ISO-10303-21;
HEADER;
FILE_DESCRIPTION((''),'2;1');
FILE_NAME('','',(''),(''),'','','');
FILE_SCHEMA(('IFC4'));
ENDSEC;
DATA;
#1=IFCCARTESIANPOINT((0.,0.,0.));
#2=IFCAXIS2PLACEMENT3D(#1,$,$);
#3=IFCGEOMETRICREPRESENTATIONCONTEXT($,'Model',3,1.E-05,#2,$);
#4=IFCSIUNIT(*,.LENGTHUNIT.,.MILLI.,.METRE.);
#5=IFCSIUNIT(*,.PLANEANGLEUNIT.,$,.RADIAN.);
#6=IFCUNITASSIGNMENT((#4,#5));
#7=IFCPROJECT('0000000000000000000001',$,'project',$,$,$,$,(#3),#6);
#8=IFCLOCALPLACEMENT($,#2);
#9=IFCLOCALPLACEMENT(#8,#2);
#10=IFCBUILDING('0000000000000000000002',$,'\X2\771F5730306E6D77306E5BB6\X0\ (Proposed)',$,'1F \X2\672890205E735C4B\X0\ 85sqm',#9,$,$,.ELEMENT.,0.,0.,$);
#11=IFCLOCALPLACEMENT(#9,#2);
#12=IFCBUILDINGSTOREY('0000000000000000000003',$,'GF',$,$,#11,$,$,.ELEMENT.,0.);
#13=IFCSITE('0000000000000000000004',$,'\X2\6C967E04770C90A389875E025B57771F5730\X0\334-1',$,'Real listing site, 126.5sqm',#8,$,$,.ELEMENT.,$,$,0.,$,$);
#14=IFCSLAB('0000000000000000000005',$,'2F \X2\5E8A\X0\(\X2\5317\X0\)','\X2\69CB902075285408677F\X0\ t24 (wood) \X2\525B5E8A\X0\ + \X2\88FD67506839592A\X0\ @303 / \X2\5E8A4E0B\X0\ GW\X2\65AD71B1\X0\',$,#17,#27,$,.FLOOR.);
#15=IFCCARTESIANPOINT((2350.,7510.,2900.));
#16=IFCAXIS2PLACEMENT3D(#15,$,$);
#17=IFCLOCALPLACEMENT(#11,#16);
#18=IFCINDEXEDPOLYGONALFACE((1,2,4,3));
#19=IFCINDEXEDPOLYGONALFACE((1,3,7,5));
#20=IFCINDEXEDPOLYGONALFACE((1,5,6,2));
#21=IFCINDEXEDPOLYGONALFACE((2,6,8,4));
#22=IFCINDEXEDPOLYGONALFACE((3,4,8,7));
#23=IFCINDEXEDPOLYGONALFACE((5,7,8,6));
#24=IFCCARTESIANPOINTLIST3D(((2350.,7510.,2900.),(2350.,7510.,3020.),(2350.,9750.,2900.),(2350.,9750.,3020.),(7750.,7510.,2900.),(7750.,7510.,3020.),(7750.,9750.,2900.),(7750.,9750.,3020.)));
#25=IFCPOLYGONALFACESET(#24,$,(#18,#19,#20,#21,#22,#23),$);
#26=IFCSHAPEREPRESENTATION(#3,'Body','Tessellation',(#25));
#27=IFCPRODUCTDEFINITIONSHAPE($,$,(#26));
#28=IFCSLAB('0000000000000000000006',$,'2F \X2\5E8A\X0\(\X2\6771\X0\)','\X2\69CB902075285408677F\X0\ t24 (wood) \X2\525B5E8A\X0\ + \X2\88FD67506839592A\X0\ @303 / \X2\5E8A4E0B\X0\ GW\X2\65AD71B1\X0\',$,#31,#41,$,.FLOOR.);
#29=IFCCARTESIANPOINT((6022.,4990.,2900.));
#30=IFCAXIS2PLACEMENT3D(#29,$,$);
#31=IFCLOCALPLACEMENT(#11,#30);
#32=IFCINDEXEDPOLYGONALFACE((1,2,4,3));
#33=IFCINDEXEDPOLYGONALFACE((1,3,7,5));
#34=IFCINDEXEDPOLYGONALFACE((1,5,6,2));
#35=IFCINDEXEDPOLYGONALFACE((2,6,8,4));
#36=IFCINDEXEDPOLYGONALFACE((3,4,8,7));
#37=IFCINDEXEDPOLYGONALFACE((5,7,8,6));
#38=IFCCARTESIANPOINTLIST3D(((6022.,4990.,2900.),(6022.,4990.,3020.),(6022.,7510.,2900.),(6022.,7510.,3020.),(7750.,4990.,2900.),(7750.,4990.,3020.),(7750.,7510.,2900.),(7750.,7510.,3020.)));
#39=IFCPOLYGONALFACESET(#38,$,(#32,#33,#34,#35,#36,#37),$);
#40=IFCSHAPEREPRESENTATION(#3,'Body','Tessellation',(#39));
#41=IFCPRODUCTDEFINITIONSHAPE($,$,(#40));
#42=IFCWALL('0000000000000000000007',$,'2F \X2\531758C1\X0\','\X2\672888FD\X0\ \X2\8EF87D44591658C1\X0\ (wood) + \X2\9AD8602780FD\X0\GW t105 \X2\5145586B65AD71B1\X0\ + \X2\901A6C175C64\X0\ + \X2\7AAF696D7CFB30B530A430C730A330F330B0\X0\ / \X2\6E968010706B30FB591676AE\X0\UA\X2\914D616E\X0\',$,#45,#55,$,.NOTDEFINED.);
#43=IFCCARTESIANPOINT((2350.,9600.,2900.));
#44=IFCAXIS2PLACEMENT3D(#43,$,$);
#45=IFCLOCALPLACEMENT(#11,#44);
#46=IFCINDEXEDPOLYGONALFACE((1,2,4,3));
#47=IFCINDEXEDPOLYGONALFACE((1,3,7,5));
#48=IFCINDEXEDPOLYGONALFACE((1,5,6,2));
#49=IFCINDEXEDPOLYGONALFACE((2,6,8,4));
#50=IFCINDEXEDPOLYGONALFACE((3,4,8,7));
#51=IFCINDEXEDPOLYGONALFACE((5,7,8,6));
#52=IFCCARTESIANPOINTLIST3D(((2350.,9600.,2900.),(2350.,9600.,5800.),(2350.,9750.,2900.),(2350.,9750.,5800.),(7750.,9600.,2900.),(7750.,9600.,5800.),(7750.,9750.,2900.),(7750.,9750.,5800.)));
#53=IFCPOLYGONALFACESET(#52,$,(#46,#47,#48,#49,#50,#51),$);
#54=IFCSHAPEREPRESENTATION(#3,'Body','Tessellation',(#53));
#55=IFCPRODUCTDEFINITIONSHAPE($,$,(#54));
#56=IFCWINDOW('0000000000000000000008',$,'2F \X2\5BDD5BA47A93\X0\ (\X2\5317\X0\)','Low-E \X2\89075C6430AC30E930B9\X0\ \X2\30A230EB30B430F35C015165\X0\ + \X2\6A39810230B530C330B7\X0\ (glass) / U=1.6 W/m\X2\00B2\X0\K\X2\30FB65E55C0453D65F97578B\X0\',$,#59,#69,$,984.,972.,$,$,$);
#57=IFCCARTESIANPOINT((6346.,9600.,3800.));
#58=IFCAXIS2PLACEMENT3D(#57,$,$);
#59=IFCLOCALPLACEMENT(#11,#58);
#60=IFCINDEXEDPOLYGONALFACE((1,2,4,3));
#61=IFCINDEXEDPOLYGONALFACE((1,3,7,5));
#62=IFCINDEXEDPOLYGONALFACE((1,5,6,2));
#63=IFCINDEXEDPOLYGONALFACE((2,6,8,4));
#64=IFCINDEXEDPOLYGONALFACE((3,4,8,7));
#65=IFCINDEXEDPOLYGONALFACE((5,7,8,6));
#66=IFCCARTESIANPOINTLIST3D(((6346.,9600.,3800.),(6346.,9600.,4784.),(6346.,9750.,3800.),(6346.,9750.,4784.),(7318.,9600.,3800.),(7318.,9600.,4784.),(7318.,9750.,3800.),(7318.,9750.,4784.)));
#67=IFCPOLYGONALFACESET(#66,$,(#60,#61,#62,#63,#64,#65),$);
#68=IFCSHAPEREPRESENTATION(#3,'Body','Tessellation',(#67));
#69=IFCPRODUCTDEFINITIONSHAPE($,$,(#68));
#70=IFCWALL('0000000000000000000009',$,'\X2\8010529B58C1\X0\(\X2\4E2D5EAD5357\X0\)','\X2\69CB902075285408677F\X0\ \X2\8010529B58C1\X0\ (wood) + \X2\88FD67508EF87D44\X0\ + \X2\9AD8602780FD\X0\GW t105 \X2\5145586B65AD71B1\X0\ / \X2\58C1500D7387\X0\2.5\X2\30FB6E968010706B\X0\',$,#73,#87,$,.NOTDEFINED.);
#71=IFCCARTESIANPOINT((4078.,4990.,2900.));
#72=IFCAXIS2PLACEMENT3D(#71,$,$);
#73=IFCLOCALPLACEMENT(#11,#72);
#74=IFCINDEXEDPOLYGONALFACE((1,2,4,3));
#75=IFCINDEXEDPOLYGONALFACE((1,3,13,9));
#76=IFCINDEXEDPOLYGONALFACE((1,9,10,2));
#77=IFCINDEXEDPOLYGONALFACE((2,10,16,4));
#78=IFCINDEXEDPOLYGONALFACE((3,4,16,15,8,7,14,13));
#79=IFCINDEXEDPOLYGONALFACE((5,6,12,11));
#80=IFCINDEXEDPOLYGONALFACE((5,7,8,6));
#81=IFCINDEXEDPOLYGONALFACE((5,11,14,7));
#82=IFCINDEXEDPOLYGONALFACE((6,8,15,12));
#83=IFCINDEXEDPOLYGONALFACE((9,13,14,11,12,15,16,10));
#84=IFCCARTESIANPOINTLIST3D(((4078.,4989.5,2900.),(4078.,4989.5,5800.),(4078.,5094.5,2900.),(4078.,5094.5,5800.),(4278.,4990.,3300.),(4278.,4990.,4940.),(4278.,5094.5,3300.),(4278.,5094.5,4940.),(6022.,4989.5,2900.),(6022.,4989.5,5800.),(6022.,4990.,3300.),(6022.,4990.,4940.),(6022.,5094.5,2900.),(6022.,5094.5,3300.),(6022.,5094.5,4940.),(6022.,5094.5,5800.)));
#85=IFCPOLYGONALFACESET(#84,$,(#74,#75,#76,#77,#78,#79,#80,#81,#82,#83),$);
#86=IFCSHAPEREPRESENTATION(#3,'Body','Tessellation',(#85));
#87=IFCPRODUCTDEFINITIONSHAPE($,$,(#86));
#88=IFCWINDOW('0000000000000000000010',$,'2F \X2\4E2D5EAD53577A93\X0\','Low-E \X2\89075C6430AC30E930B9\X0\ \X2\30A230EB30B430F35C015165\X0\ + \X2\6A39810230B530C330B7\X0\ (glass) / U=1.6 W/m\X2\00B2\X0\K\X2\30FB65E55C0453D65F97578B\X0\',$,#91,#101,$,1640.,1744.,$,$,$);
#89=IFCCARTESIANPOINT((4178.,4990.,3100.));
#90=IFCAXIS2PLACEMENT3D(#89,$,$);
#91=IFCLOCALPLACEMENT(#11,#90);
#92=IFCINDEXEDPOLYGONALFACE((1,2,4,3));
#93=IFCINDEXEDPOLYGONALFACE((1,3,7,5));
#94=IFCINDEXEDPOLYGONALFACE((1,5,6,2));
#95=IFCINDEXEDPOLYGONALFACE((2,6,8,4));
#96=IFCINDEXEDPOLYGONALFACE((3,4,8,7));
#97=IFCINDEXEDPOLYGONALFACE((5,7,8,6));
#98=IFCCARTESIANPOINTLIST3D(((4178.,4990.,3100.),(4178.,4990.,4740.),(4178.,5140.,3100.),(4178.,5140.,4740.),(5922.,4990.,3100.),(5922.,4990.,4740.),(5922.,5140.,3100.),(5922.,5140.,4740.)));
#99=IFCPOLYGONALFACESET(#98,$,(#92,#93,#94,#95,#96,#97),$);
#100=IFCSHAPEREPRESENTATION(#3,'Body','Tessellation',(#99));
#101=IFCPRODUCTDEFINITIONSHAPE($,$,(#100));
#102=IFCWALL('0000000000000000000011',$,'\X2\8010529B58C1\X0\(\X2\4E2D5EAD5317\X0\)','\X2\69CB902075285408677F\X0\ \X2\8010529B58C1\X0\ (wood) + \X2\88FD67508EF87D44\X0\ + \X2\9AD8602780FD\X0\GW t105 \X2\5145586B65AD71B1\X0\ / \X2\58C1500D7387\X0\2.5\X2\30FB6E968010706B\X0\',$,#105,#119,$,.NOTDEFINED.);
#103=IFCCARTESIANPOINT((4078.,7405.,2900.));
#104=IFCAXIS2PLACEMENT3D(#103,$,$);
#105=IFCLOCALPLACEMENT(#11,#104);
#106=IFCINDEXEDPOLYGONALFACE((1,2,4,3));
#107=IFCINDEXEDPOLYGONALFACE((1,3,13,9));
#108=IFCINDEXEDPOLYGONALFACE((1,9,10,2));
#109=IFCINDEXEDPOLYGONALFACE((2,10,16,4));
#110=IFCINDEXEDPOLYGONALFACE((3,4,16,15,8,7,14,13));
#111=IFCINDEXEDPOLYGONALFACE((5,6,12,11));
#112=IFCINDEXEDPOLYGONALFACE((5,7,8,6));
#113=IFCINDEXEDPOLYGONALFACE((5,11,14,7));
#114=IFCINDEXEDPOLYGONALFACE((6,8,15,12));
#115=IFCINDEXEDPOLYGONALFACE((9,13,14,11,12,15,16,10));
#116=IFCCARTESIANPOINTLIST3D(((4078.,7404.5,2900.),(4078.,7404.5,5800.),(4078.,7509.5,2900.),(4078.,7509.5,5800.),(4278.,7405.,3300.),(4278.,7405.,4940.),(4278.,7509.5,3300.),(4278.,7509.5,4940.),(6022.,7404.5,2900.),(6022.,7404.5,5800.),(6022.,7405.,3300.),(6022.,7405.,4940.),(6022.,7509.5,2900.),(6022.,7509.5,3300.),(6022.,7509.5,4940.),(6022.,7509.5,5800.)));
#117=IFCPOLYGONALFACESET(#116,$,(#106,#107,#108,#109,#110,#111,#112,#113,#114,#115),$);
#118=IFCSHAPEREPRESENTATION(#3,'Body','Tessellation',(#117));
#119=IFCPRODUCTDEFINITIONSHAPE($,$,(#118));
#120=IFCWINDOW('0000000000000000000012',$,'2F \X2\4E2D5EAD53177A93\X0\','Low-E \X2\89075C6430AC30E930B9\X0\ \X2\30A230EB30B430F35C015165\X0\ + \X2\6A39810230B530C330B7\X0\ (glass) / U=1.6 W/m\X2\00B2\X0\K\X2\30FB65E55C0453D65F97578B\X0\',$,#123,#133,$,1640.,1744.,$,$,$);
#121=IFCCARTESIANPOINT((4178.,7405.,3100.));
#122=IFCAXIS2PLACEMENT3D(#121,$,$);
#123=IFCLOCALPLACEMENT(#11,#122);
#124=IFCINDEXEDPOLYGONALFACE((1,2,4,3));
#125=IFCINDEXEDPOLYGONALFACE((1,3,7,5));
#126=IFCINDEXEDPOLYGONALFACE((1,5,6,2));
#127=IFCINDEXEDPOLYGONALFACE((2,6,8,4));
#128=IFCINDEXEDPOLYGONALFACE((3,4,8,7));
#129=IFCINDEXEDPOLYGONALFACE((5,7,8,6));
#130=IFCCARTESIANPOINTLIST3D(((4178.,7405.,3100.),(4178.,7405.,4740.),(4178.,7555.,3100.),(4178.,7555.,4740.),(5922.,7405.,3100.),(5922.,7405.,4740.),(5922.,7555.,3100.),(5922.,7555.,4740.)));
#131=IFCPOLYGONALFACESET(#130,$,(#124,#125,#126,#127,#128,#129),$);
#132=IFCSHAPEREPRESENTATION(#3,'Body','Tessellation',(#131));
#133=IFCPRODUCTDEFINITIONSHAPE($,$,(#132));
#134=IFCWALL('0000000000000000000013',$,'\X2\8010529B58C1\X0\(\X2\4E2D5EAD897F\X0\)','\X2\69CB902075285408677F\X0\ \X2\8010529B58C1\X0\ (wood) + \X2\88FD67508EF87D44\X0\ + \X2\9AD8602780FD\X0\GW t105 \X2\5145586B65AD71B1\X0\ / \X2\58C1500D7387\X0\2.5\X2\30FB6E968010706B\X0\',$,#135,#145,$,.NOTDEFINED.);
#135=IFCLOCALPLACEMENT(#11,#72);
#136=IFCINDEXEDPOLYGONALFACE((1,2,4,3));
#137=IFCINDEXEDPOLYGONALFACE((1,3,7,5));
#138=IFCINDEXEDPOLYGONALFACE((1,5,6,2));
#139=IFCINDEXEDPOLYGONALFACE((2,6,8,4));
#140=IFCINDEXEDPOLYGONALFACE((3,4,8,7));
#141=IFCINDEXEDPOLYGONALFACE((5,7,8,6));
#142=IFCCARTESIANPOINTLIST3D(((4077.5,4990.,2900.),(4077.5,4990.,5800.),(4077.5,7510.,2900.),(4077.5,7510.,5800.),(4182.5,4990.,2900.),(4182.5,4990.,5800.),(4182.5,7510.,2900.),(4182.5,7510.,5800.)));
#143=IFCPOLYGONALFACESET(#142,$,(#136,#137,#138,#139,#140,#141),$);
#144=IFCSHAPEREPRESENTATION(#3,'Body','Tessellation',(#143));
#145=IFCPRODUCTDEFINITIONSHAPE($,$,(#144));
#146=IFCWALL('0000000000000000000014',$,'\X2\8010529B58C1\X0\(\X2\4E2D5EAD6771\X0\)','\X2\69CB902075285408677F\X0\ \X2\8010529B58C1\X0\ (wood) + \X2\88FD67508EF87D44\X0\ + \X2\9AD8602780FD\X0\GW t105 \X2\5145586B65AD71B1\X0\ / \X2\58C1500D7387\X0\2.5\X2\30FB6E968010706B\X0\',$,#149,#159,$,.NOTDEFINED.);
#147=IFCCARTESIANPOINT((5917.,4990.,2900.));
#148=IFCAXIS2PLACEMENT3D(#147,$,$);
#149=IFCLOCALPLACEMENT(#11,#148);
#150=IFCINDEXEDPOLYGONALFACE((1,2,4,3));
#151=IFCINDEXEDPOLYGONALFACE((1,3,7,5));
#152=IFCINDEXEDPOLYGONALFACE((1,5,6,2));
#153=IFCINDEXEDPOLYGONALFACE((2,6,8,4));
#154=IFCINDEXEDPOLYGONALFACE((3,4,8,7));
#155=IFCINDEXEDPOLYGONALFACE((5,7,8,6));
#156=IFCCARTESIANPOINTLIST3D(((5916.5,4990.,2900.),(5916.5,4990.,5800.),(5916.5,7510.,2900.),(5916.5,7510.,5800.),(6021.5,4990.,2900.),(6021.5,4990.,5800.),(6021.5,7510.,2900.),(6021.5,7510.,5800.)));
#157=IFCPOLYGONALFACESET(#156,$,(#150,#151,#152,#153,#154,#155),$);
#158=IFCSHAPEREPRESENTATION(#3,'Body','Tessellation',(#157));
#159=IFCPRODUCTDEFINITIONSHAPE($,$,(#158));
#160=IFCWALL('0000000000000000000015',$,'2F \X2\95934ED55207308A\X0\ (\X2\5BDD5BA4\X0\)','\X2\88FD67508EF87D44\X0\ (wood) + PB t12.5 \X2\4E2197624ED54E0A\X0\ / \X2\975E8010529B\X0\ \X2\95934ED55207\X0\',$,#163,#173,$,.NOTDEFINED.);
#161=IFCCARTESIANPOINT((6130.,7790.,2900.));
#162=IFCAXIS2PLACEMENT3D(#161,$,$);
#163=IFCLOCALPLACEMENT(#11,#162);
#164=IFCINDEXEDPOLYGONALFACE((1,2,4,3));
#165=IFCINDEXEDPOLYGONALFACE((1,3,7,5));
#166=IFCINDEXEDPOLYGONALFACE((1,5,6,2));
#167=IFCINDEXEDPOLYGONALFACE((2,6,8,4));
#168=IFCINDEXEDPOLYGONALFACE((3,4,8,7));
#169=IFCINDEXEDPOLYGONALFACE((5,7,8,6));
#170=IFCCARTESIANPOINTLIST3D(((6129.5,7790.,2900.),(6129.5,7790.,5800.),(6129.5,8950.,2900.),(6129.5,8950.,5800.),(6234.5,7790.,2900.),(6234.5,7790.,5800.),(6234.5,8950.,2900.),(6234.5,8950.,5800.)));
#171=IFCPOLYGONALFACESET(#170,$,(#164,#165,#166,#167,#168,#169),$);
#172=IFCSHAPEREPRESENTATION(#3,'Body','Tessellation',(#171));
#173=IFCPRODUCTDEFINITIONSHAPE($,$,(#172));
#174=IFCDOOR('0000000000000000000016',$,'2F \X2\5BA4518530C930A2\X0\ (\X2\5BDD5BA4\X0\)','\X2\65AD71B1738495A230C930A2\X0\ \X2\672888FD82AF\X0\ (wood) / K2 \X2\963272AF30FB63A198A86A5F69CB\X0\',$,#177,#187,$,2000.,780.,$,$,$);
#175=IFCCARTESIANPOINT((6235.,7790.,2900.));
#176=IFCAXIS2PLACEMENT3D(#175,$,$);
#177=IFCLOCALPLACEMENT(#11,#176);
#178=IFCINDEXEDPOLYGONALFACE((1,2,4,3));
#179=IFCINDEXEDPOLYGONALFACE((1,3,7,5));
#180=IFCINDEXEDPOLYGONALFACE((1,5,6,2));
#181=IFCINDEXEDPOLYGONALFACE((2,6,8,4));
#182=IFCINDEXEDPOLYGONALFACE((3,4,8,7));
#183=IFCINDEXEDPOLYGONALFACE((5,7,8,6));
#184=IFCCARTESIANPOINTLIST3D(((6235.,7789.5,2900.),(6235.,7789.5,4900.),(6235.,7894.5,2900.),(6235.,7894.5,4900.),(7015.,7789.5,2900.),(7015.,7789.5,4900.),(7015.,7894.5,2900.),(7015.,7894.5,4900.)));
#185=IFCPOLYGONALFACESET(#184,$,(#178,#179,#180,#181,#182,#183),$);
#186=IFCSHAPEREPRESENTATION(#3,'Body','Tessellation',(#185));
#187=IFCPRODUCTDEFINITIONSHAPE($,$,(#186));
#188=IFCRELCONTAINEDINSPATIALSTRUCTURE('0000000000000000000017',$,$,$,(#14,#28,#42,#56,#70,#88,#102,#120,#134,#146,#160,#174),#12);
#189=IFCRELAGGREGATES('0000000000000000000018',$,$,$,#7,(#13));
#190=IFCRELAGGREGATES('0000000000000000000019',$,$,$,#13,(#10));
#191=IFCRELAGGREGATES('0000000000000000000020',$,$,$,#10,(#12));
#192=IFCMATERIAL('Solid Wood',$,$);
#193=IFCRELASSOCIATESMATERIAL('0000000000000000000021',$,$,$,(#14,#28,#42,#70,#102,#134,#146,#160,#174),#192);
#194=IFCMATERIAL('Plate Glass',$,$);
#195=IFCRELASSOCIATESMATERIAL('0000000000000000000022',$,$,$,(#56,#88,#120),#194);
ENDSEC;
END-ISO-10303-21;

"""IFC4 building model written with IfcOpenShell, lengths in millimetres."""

from ifc_helpers import new_model, si_unit, frame, frame_2d, origin, place, context, project, spatial, rectangle, extrude, material, element, fill, save


model = new_model("IFC4")

# Units and contexts
model_context = context("Model", 3, precision=1e-05, world=origin())
ifc_project = project(units=[si_unit("LENGTHUNIT", "METRE", prefix="MILLI"), si_unit("PLANEANGLEUNIT", "RADIAN")], contexts=[model_context])

# Site, building, storey
site_placement = place(None, origin())
site = spatial("IfcSite", under=ifc_project, at=site_placement, Name="沖縄県那覇市字真地334-1", ObjectType="Real listing site, 126.5sqm", CompositionType="ELEMENT", RefElevation=0.0)
building_placement = place(site_placement, origin())
building = spatial("IfcBuilding", under=site, at=building_placement, Name="真地の海の家 (Proposed)", ObjectType="1F 木造平屋 85sqm", CompositionType="ELEMENT", ElevationOfRefHeight=0.0, ElevationOfTerrain=0.0)
storey_placement = place(building_placement, origin())
storey = spatial("IfcBuildingStorey", under=building, at=storey_placement, Name="GF", CompositionType="ELEMENT", Elevation=0.0)

# Slabs
ifc_material_1 = material(Name="Solid Wood")
slab_1_placement = place(storey_placement, frame((2350.0, 7510.0, 2900.0)))
element("IfcSlab", 1, at=slab_1_placement, inside=storey, material=ifc_material_1, Name="2F 床(北)", Description="構造用合板 t24 (wood) 剛床 + 製材根太 @303 / 床下 GW断熱", PredefinedType="FLOOR", context=model_context, shape_type="SweptSolid", body=[
    extrude(rectangle(XDim=5400.0, YDim=2240.0, at=frame_2d((2700.0, 1120.0))), frame((2350.0, 7510.0, 2900.0)), (0.0, 0.0, 1.0), 120.0),
])
slab_2_placement = place(storey_placement, frame((6022.0, 4990.0, 2900.0)))
element("IfcSlab", 2, at=slab_2_placement, inside=storey, material=ifc_material_1, Name="2F 床(東)", Description="構造用合板 t24 (wood) 剛床 + 製材根太 @303 / 床下 GW断熱", PredefinedType="FLOOR", context=model_context, shape_type="SweptSolid", body=[
    extrude(rectangle(XDim=1728.0, YDim=2520.0, at=frame_2d((864.0, 1260.0))), frame((6022.0, 4990.0, 2900.0)), (0.0, 0.0, 1.0), 120.0),
])

# Walls, openings, windows
wall_1_placement = place(storey_placement, frame((2350.0, 9600.0, 2900.0)))
wall_1 = element("IfcWall", 3, at=wall_1_placement, inside=storey, material=ifc_material_1, Name="2F 北壁", Description="木製 軸組外壁 (wood) + 高性能GW t105 充填断熱 + 通気層 + 窯業系サイディング / 準耐火・外皮UA配慮", PredefinedType="NOTDEFINED", context=model_context, shape_type="SweptSolid", body=[
    extrude(rectangle(XDim=5400.0, YDim=150.0, at=frame_2d((2700.0, 75.0))), frame((2350.0, 9600.0, 2900.0)), (0.0, 0.0, 1.0), 2900.0),
])
opening_1_placement = place(storey_placement, frame((6346.0, 9600.0, 3800.0)))
opening_1 = element("IfcOpeningElement", 4, at=opening_1_placement, cuts=wall_1, PredefinedType="NOTDEFINED", context=model_context, shape_type="SweptSolid", body=[
    extrude(rectangle(XDim=972.0, YDim=150.0, at=frame_2d((486.0, 75.0))), frame((6346.0, 9600.0, 3800.0)), (0.0, 0.0, 1.0), 984.0),
])
ifc_material_2 = material(Name="Plate Glass")
window_1_placement = place(storey_placement, frame((6346.0, 9600.0, 3800.0)))
window_1 = element("IfcWindow", 5, at=window_1_placement, inside=storey, material=ifc_material_2, Name="2F 寝室窓 (北)", Description="Low-E 複層ガラス アルゴン封入 + 樹脂サッシ (glass) / U=1.6 W/m²K・日射取得型", OverallHeight=984.0, OverallWidth=972.0, context=model_context, shape_type="SweptSolid", body=[
    extrude(rectangle(XDim=972.0, YDim=150.0, at=frame_2d((486.0, 75.0))), frame((6346.0, 9600.0, 3800.0)), (0.0, 0.0, 1.0), 984.0),
])
fill(opening_1, window_1)
wall_2_placement = place(storey_placement, frame((4078.0, 4990.0, 2900.0)))
wall_2 = element("IfcWall", 6, at=wall_2_placement, inside=storey, material=ifc_material_1, Name="耐力壁(中庭南)", Description="構造用合板 耐力壁 (wood) + 製材軸組 + 高性能GW t105 充填断熱 / 壁倍率2.5・準耐火", PredefinedType="NOTDEFINED", context=model_context, shape_type="SweptSolid", body=[
    extrude(rectangle(XDim=1944.0, YDim=105.0, at=frame_2d((972.0, 52.0))), frame((4078.0, 4990.0, 2900.0)), (0.0, 0.0, 1.0), 2900.0),
])
opening_2_placement = place(storey_placement, frame((4178.0, 4990.0, 3100.0)))
opening_2 = element("IfcOpeningElement", 7, at=opening_2_placement, cuts=wall_2, PredefinedType="NOTDEFINED", context=model_context, shape_type="SweptSolid", body=[
    extrude(rectangle(XDim=1744.0, YDim=150.0, at=frame_2d((872.0, 75.0))), frame((4178.0, 4990.0, 3100.0)), (0.0, 0.0, 1.0), 1640.0),
])
window_2_placement = place(storey_placement, frame((4178.0, 4990.0, 3100.0)))
window_2 = element("IfcWindow", 8, at=window_2_placement, inside=storey, material=ifc_material_2, Name="2F 中庭南窓", Description="Low-E 複層ガラス アルゴン封入 + 樹脂サッシ (glass) / U=1.6 W/m²K・日射取得型", OverallHeight=1640.0, OverallWidth=1744.0, context=model_context, shape_type="SweptSolid", body=[
    extrude(rectangle(XDim=1744.0, YDim=150.0, at=frame_2d((872.0, 75.0))), frame((4178.0, 4990.0, 3100.0)), (0.0, 0.0, 1.0), 1640.0),
])
fill(opening_2, window_2)
wall_3_placement = place(storey_placement, frame((4078.0, 7405.0, 2900.0)))
wall_3 = element("IfcWall", 9, at=wall_3_placement, inside=storey, material=ifc_material_1, Name="耐力壁(中庭北)", Description="構造用合板 耐力壁 (wood) + 製材軸組 + 高性能GW t105 充填断熱 / 壁倍率2.5・準耐火", PredefinedType="NOTDEFINED", context=model_context, shape_type="SweptSolid", body=[
    extrude(rectangle(XDim=1944.0, YDim=105.0, at=frame_2d((972.0, 52.0))), frame((4078.0, 7405.0, 2900.0)), (0.0, 0.0, 1.0), 2900.0),
])
opening_3_placement = place(storey_placement, frame((4178.0, 7405.0, 3100.0)))
opening_3 = element("IfcOpeningElement", 10, at=opening_3_placement, cuts=wall_3, PredefinedType="NOTDEFINED", context=model_context, shape_type="SweptSolid", body=[
    extrude(rectangle(XDim=1744.0, YDim=150.0, at=frame_2d((872.0, 75.0))), frame((4178.0, 7405.0, 3100.0)), (0.0, 0.0, 1.0), 1640.0),
])
window_3_placement = place(storey_placement, frame((4178.0, 7405.0, 3100.0)))
window_3 = element("IfcWindow", 11, at=window_3_placement, inside=storey, material=ifc_material_2, Name="2F 中庭北窓", Description="Low-E 複層ガラス アルゴン封入 + 樹脂サッシ (glass) / U=1.6 W/m²K・日射取得型", OverallHeight=1640.0, OverallWidth=1744.0, context=model_context, shape_type="SweptSolid", body=[
    extrude(rectangle(XDim=1744.0, YDim=150.0, at=frame_2d((872.0, 75.0))), frame((4178.0, 7405.0, 3100.0)), (0.0, 0.0, 1.0), 1640.0),
])
fill(opening_3, window_3)

# Walls
wall_4_placement = place(storey_placement, frame((4078.0, 4990.0, 2900.0)))
element("IfcWall", 12, at=wall_4_placement, inside=storey, material=ifc_material_1, Name="耐力壁(中庭西)", Description="構造用合板 耐力壁 (wood) + 製材軸組 + 高性能GW t105 充填断熱 / 壁倍率2.5・準耐火", PredefinedType="NOTDEFINED", context=model_context, shape_type="SweptSolid", body=[
    extrude(rectangle(XDim=105.0, YDim=2520.0, at=frame_2d((52.0, 1260.0))), frame((4078.0, 4990.0, 2900.0)), (0.0, 0.0, 1.0), 2900.0),
])
wall_5_placement = place(storey_placement, frame((5917.0, 4990.0, 2900.0)))
element("IfcWall", 13, at=wall_5_placement, inside=storey, material=ifc_material_1, Name="耐力壁(中庭東)", Description="構造用合板 耐力壁 (wood) + 製材軸組 + 高性能GW t105 充填断熱 / 壁倍率2.5・準耐火", PredefinedType="NOTDEFINED", context=model_context, shape_type="SweptSolid", body=[
    extrude(rectangle(XDim=105.0, YDim=2520.0, at=frame_2d((52.0, 1260.0))), frame((5917.0, 4990.0, 2900.0)), (0.0, 0.0, 1.0), 2900.0),
])
wall_6_placement = place(storey_placement, frame((6130.0, 7790.0, 2900.0)))
element("IfcWall", 14, at=wall_6_placement, inside=storey, material=ifc_material_1, Name="2F 間仕切り (寝室)", Description="製材軸組 (wood) + PB t12.5 両面仕上 / 非耐力 間仕切", PredefinedType="NOTDEFINED", context=model_context, shape_type="SweptSolid", body=[
    extrude(rectangle(XDim=105.0, YDim=1160.0, at=frame_2d((52.0, 580.0))), frame((6130.0, 7790.0, 2900.0)), (0.0, 0.0, 1.0), 2900.0),
])

# Door
door_placement = place(storey_placement, frame((6235.0, 7790.0, 2900.0)))
element("IfcDoor", 15, at=door_placement, inside=storey, material=ifc_material_1, Name="2F 室内ドア (寝室)", Description="断熱玄関ドア 木製芯 (wood) / K2 防犯・採風機構", OverallHeight=2000.0, OverallWidth=780.0, context=model_context, shape_type="SweptSolid", body=[
    extrude(rectangle(XDim=780.0, YDim=105.0, at=frame_2d((390.0, 52.0))), frame((6235.0, 7790.0, 2900.0)), (0.0, 0.0, 1.0), 2000.0),
])

save(model, "model.ifc")
